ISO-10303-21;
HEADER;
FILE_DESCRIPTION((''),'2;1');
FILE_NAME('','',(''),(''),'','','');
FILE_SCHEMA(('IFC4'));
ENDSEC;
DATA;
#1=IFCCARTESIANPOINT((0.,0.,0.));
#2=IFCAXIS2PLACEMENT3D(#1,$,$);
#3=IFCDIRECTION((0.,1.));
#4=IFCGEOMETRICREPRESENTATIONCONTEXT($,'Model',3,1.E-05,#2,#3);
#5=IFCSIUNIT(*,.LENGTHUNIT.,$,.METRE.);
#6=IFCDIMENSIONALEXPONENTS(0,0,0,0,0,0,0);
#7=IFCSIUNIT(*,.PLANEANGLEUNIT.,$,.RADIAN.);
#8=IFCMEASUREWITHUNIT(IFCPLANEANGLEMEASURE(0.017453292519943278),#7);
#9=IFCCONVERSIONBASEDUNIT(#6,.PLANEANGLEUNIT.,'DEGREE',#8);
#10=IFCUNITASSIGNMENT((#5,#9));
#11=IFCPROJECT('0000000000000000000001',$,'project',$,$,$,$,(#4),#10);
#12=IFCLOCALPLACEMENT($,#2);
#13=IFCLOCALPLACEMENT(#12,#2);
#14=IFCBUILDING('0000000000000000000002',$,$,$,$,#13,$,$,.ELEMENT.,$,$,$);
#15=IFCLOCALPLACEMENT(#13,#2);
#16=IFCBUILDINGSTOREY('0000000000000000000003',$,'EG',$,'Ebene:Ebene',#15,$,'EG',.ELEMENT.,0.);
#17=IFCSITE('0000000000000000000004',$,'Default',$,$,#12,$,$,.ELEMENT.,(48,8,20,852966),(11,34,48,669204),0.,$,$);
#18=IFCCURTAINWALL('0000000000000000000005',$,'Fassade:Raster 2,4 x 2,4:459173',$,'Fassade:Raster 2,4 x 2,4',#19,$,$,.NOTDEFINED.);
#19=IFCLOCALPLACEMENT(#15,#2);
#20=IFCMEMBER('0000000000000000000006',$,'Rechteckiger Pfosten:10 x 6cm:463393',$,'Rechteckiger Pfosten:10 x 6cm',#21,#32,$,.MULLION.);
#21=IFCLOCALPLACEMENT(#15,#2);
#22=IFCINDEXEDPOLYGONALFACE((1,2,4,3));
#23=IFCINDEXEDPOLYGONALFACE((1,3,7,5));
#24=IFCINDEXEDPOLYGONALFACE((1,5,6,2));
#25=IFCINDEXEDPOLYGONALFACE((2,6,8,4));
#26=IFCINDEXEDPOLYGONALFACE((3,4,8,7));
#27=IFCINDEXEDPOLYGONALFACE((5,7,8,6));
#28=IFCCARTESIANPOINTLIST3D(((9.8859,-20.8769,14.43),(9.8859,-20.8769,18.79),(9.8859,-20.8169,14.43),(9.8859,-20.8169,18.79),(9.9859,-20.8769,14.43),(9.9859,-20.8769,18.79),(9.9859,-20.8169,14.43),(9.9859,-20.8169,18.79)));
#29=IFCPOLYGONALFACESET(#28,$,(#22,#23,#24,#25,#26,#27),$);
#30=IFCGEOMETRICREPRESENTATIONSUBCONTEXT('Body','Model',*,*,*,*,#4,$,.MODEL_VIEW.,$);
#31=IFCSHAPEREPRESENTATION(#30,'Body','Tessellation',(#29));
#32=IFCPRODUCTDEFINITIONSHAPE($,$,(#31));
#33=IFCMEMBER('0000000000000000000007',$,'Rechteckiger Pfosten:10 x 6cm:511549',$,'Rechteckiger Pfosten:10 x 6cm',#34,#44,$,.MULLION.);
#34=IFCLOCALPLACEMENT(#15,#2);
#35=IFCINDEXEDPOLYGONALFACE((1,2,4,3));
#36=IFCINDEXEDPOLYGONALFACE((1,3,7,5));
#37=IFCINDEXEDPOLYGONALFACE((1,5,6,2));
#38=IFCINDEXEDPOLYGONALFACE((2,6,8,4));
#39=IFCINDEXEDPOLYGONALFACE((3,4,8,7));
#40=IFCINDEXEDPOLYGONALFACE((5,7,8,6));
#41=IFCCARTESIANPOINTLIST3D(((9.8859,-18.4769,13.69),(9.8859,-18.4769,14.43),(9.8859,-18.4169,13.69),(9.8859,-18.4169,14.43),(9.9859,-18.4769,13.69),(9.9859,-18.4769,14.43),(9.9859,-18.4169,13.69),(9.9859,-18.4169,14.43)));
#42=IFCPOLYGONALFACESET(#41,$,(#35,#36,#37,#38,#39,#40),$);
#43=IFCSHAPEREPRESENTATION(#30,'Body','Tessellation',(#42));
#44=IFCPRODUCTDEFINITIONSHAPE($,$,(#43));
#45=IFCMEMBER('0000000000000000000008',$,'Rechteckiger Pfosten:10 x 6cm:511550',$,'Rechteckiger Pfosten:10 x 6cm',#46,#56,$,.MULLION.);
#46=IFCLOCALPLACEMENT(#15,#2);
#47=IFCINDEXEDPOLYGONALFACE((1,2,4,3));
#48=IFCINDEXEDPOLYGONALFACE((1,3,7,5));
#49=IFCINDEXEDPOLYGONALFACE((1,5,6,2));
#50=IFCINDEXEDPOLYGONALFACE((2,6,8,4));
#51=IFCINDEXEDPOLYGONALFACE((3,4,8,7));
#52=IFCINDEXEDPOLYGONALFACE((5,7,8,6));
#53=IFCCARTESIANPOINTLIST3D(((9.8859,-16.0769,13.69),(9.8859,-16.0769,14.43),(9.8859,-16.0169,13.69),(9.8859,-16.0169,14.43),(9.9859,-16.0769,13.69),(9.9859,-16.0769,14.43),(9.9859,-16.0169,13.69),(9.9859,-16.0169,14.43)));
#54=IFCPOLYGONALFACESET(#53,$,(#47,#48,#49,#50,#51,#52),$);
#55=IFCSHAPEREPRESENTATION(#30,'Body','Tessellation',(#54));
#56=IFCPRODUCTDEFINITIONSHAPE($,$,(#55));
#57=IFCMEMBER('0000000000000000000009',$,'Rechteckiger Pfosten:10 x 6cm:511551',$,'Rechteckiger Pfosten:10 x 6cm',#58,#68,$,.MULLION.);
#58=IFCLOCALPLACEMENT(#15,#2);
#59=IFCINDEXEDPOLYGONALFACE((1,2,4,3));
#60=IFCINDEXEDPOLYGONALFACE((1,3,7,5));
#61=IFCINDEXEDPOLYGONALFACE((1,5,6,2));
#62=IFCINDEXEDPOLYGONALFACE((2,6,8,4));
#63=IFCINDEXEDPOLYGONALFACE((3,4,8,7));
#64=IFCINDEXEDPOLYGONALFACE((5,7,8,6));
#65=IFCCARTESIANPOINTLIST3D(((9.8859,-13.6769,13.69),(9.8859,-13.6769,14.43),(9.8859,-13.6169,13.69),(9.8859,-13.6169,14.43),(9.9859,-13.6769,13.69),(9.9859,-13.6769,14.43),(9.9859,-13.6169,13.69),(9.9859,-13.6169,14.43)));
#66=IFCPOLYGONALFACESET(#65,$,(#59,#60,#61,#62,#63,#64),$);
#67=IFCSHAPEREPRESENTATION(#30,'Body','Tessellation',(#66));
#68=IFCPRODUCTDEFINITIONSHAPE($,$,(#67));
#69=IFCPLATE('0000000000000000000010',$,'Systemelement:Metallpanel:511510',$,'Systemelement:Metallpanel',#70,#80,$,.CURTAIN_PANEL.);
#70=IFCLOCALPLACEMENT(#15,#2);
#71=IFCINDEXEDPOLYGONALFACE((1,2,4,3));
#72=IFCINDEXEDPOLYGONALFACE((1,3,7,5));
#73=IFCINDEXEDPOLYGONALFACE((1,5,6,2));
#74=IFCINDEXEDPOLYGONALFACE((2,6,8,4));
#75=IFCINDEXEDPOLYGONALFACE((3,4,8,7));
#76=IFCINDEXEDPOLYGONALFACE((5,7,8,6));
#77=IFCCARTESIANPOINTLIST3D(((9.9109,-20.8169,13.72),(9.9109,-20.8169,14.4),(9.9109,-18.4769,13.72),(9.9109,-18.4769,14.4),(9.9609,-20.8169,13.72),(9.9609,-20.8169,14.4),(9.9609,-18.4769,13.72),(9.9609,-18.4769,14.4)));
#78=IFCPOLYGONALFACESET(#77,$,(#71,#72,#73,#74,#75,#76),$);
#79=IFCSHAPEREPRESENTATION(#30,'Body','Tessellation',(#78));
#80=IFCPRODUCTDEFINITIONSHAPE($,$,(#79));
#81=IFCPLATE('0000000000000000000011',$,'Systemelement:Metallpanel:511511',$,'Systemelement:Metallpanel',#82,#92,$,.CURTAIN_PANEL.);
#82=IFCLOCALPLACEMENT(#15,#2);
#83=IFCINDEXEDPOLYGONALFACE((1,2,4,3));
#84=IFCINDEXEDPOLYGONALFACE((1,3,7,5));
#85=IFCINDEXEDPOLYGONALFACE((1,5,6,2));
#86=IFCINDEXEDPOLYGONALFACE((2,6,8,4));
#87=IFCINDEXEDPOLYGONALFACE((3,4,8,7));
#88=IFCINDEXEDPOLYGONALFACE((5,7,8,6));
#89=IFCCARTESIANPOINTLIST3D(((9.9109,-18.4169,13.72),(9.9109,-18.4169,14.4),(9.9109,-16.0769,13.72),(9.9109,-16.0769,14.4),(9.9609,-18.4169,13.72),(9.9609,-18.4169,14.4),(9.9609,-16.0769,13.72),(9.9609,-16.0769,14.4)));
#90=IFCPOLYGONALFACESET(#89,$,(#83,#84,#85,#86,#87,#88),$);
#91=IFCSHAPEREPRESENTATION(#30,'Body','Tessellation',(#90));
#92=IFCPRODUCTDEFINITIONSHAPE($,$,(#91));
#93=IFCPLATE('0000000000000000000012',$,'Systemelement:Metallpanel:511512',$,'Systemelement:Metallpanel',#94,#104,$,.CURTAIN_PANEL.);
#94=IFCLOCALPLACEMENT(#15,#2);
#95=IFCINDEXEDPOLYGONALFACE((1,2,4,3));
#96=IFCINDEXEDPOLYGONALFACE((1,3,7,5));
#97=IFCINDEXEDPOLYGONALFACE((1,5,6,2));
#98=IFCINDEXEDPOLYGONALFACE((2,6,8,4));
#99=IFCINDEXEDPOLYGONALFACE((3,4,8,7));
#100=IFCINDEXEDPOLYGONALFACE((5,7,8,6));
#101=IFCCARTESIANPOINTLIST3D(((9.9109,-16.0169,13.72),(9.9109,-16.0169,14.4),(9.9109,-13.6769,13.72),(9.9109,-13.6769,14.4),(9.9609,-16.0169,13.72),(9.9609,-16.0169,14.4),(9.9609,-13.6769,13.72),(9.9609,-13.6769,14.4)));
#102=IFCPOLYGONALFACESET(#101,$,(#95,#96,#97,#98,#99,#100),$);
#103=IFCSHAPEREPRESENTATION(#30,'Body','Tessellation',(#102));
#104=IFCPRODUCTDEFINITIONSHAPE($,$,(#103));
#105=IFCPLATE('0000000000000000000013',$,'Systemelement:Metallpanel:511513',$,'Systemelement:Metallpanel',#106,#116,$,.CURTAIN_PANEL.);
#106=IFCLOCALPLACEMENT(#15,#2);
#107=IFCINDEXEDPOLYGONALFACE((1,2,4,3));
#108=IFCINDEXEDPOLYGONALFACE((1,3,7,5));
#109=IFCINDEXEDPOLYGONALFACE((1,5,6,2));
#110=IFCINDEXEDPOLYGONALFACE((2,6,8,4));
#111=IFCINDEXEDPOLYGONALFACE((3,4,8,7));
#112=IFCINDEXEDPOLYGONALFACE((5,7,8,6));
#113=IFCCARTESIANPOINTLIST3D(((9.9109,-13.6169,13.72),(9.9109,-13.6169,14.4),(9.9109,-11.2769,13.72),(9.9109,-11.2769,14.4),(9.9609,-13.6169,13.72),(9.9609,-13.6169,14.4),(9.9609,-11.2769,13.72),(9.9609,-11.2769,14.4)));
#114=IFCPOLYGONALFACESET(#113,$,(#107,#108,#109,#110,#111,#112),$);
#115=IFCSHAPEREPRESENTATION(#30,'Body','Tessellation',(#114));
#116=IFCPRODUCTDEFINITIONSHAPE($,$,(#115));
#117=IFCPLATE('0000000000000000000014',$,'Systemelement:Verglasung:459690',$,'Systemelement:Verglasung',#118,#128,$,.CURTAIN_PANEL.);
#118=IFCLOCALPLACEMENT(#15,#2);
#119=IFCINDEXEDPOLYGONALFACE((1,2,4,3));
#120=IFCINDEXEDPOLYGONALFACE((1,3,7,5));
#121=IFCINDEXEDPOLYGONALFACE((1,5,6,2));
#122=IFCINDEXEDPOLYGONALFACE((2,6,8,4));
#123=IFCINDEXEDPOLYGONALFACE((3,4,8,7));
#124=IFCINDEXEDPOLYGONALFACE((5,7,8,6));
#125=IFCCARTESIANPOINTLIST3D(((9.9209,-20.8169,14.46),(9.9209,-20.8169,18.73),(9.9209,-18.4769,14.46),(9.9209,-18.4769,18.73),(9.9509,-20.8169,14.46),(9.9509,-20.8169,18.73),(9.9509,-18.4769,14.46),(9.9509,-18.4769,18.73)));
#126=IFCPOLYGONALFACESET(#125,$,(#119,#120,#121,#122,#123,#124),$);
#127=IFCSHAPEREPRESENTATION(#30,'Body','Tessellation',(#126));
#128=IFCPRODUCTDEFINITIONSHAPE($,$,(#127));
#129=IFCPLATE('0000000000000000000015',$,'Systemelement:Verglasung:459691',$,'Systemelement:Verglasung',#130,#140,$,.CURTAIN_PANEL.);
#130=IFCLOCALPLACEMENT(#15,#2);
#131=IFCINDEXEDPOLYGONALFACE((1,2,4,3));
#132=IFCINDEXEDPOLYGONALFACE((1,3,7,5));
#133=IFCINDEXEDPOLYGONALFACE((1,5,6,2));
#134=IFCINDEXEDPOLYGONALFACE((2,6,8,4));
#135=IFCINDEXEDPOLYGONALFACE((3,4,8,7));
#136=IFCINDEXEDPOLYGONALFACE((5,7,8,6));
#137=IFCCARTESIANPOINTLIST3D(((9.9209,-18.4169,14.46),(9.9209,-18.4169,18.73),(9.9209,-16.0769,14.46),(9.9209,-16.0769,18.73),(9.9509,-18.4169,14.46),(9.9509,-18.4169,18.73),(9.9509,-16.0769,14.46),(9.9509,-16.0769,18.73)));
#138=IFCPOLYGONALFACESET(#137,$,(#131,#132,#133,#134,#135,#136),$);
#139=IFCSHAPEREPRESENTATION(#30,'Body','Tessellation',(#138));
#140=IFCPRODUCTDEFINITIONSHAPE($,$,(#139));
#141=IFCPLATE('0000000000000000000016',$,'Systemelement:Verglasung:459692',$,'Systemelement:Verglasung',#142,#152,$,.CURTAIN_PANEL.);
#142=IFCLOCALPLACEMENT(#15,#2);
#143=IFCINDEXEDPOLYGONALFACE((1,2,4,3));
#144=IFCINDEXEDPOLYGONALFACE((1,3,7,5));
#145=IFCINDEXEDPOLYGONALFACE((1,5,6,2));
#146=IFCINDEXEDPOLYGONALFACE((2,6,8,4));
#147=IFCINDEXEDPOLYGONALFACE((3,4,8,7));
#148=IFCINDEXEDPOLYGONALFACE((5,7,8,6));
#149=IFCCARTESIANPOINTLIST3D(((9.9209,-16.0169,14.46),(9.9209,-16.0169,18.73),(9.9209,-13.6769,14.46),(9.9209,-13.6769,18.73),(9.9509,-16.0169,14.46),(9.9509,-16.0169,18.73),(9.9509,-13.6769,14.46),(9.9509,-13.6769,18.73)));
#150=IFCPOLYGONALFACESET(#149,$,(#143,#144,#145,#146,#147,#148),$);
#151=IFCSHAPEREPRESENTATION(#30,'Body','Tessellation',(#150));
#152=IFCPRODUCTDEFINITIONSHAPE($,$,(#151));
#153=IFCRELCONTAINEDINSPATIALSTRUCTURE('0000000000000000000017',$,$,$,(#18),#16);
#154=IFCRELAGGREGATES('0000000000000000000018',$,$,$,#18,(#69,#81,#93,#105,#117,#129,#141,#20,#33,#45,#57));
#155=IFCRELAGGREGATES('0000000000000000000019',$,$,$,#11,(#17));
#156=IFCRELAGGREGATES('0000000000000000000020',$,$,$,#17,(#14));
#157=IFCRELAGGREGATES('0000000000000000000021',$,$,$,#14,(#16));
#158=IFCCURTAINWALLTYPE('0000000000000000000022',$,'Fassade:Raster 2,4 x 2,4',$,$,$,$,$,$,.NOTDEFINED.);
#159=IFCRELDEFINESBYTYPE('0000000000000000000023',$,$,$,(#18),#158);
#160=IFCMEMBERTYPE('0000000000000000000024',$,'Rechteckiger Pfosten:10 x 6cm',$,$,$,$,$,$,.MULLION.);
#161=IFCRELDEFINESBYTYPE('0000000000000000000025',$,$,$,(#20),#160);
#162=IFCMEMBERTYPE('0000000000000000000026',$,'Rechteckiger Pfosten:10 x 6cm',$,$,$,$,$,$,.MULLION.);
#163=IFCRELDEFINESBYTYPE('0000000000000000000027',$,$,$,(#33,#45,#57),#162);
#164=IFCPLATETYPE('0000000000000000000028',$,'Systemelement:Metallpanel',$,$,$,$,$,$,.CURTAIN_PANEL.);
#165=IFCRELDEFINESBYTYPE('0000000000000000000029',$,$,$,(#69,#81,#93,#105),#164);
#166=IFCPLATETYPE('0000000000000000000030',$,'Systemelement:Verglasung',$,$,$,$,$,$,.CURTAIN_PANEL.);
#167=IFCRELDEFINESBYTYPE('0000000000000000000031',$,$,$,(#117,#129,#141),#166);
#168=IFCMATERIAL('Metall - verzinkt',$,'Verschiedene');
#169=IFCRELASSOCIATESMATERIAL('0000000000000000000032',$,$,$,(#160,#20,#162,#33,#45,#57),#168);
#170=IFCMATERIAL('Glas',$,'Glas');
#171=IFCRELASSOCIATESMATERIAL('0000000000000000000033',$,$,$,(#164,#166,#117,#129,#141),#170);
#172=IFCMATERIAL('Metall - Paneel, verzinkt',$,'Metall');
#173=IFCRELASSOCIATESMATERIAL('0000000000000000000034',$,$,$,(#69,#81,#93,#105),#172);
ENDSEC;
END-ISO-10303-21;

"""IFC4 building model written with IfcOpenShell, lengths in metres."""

from ifc_helpers import new_model, entity, si_unit, converted_unit, direction, frame, origin, place, context, subcontext, project, spatial, indexed_curve, outline, extrude, source, transform, mapped, material, type_object, type_shapes, element, aggregate, save


model = new_model("IFC4")

# Units and contexts
model_context = context("Model", 3, precision=1e-05, world=origin(), true_north=direction((0.0, 1.0)))
body_context = subcontext(model_context, "Body", "Model", "MODEL_VIEW")
ifc_project = project(units=[si_unit("LENGTHUNIT", "METRE"), converted_unit("PLANEANGLEUNIT", "DEGREE", entity("IfcPlaneAngleMeasure", 0.017453292519943278), si_unit("PLANEANGLEUNIT", "RADIAN"), dimensions=[0, 0, 0, 0, 0, 0, 0])], contexts=[model_context])

# Site, building, storey
site_placement = place(None, origin())
site = spatial("IfcSite", under=ifc_project, at=site_placement, Name="Default", CompositionType="ELEMENT", RefLatitude=(48, 8, 20, 852966), RefLongitude=(11, 34, 48, 669204), RefElevation=0.0)
building_placement = place(site_placement, origin())
building = spatial("IfcBuilding", under=site, at=building_placement, CompositionType="ELEMENT")
storey_placement = place(building_placement, origin())
storey = spatial("IfcBuildingStorey", under=building, at=storey_placement, Name="EG", ObjectType="Ebene:Ebene", LongName="EG", CompositionType="ELEMENT", Elevation=0.0)

# Curtain wall, members, plates
curtain_wall_type = type_object("IfcCurtainWallType", Name="Fassade:Raster 2,4 x 2,4", PredefinedType="NOTDEFINED")
curtain_wall_placement = place(storey_placement, origin())
curtain_wall = element("IfcCurtainWall", 1, at=curtain_wall_placement, inside=storey, type_object=curtain_wall_type, Name="Fassade:Raster 2,4 x 2,4:459173", ObjectType="Fassade:Raster 2,4 x 2,4", PredefinedType="NOTDEFINED")
ifc_material_1 = material(Name="Metall - verzinkt", Category="Verschiedene")
member_type_1 = type_object("IfcMemberType", Name="Rechteckiger Pfosten:10 x 6cm", PredefinedType="MULLION", material=ifc_material_1)
shared_shape_1 = source(origin(), body_context, "Body", "SweptSolid", [
    extrude(outline(indexed_curve([(-0.03, -0.05), (0.03, -0.05), (0.03, 0.05), (-0.03, 0.05), (-0.03, -0.05)], self_intersect=False)), frame((-0.03, 0.0, -4.36), z_axis=(0.0, 0.0, 1.0), x_axis=(-1.0, 0.0, 0.0)), (0.0, 0.0, 1.0), 4.36),
])
type_shapes(member_type_1, [shared_shape_1])
member_1_placement = place(curtain_wall_placement, frame((9.9359, -20.8769, 18.79), z_axis=(0.0, 0.0, 1.0), x_axis=(0.0, -1.0, 0.0)))
member_1 = element("IfcMember", 2, at=member_1_placement, type_object=member_type_1, material=ifc_material_1, Name="Rechteckiger Pfosten:10 x 6cm:463393", ObjectType="Rechteckiger Pfosten:10 x 6cm", PredefinedType="MULLION", context=body_context, shape_type="MappedRepresentation", body=[
    mapped(shared_shape_1, transform((0.0, 0.0, 0.0), scale=1.0)),
])
member_type_2 = type_object("IfcMemberType", Name="Rechteckiger Pfosten:10 x 6cm", PredefinedType="MULLION", material=ifc_material_1)
shared_shape_2 = source(origin(), body_context, "Body", "SweptSolid", [
    extrude(outline(indexed_curve([(-0.03, -0.05), (0.03, -0.05), (0.03, 0.05), (-0.03, 0.05), (-0.03, -0.05)], self_intersect=False)), frame((0.0, 0.0, -0.74), z_axis=(0.0, 0.0, 1.0), x_axis=(-1.0, 0.0, 0.0)), (0.0, 0.0, 1.0), 0.74),
])
type_shapes(member_type_2, [shared_shape_2])
member_2_placement = place(curtain_wall_placement, frame((9.9359, -18.4469, 13.69), z_axis=(0.0, 0.0, -1.0), x_axis=(0.0, 1.0, 0.0)))
member_2 = element("IfcMember", 3, at=member_2_placement, type_object=member_type_2, material=ifc_material_1, Name="Rechteckiger Pfosten:10 x 6cm:511549", ObjectType="Rechteckiger Pfosten:10 x 6cm", PredefinedType="MULLION", context=body_context, shape_type="MappedRepresentation", body=[
    mapped(shared_shape_2, transform((0.0, 0.0, 0.0), scale=1.0)),
])
member_3_placement = place(curtain_wall_placement, frame((9.9359, -16.0469, 13.69), z_axis=(0.0, 0.0, -1.0), x_axis=(0.0, 1.0, 0.0)))
member_3 = element("IfcMember", 4, at=member_3_placement, type_object=member_type_2, material=ifc_material_1, Name="Rechteckiger Pfosten:10 x 6cm:511550", ObjectType="Rechteckiger Pfosten:10 x 6cm", PredefinedType="MULLION", context=body_context, shape_type="MappedRepresentation", body=[
    mapped(shared_shape_2, transform((0.0, 0.0, 0.0), scale=1.0)),
])
member_4_placement = place(curtain_wall_placement, frame((9.9359, -13.6469, 13.69), z_axis=(0.0, 0.0, -1.0), x_axis=(0.0, 1.0, 0.0)))
member_4 = element("IfcMember", 5, at=member_4_placement, type_object=member_type_2, material=ifc_material_1, Name="Rechteckiger Pfosten:10 x 6cm:511551", ObjectType="Rechteckiger Pfosten:10 x 6cm", PredefinedType="MULLION", context=body_context, shape_type="MappedRepresentation", body=[
    mapped(shared_shape_2, transform((0.0, 0.0, 0.0), scale=1.0)),
])
ifc_material_2 = material(Name="Metall - Paneel, verzinkt", Category="Metall")
ifc_material_3 = material(Name="Glas", Category="Glas")
plate_type_1 = type_object("IfcPlateType", Name="Systemelement:Metallpanel", PredefinedType="CURTAIN_PANEL", material=ifc_material_3)
shared_shape_3 = source(origin(), body_context, "Body", "SweptSolid", [
    extrude(outline(indexed_curve([(-0.025, -1.17), (0.025, -1.17), (0.025, 1.17), (-0.025, 1.17), (-0.025, -1.17)], self_intersect=False)), frame((0.0, 0.0, 0.0), z_axis=(0.0, 0.0, 1.0), x_axis=(0.0, 1.0, 0.0)), (0.0, 0.0, 1.0), 0.68),
])
type_shapes(plate_type_1, [shared_shape_3])
plate_1_placement = place(curtain_wall_placement, frame((9.9359, -19.6469, 13.72), z_axis=(0.0, 0.0, 1.0), x_axis=(0.0, 1.0, 0.0)))
plate_1 = element("IfcPlate", 6, at=plate_1_placement, type_object=plate_type_1, material=ifc_material_2, Name="Systemelement:Metallpanel:511510", ObjectType="Systemelement:Metallpanel", PredefinedType="CURTAIN_PANEL", context=body_context, shape_type="MappedRepresentation", body=[
    mapped(shared_shape_3, transform((0.0, 0.0, 0.0), scale=1.0)),
])
plate_2_placement = place(curtain_wall_placement, frame((9.9359, -17.2469, 13.72), z_axis=(0.0, 0.0, 1.0), x_axis=(0.0, 1.0, 0.0)))
plate_2 = element("IfcPlate", 7, at=plate_2_placement, type_object=plate_type_1, material=ifc_material_2, Name="Systemelement:Metallpanel:511511", ObjectType="Systemelement:Metallpanel", PredefinedType="CURTAIN_PANEL", context=body_context, shape_type="MappedRepresentation", body=[
    mapped(shared_shape_3, transform((0.0, 0.0, 0.0), scale=1.0)),
])
plate_3_placement = place(curtain_wall_placement, frame((9.9359, -14.8469, 13.72), z_axis=(0.0, 0.0, 1.0), x_axis=(0.0, 1.0, 0.0)))
plate_3 = element("IfcPlate", 8, at=plate_3_placement, type_object=plate_type_1, material=ifc_material_2, Name="Systemelement:Metallpanel:511512", ObjectType="Systemelement:Metallpanel", PredefinedType="CURTAIN_PANEL", context=body_context, shape_type="MappedRepresentation", body=[
    mapped(shared_shape_3, transform((0.0, 0.0, 0.0), scale=1.0)),
])
plate_4_placement = place(curtain_wall_placement, frame((9.9359, -12.4469, 13.72), z_axis=(0.0, 0.0, 1.0), x_axis=(0.0, 1.0, 0.0)))
plate_4 = element("IfcPlate", 9, at=plate_4_placement, type_object=plate_type_1, material=ifc_material_2, Name="Systemelement:Metallpanel:511513", ObjectType="Systemelement:Metallpanel", PredefinedType="CURTAIN_PANEL", context=body_context, shape_type="MappedRepresentation", body=[
    mapped(shared_shape_3, transform((0.0, 0.0, 0.0), scale=1.0)),
])
plate_type_2 = type_object("IfcPlateType", Name="Systemelement:Verglasung", PredefinedType="CURTAIN_PANEL", material=ifc_material_3)
shared_shape_4 = source(origin(), body_context, "Body", "SweptSolid", [
    extrude(outline(indexed_curve([(-0.015, -1.17), (0.015, -1.17), (0.015, 1.17), (-0.015, 1.17), (-0.015, -1.17)], self_intersect=False)), frame((0.0, 0.0, 0.0), z_axis=(0.0, 0.0, 1.0), x_axis=(0.0, 1.0, 0.0)), (0.0, 0.0, 1.0), 4.27),
])
type_shapes(plate_type_2, [shared_shape_4])
plate_5_placement = place(curtain_wall_placement, frame((9.9359, -19.6469, 14.46), z_axis=(0.0, 0.0, 1.0), x_axis=(0.0, 1.0, 0.0)))
plate_5 = element("IfcPlate", 10, at=plate_5_placement, type_object=plate_type_2, material=ifc_material_3, Name="Systemelement:Verglasung:459690", ObjectType="Systemelement:Verglasung", PredefinedType="CURTAIN_PANEL", context=body_context, shape_type="MappedRepresentation", body=[
    mapped(shared_shape_4, transform((0.0, 0.0, 0.0), scale=1.0)),
])
plate_6_placement = place(curtain_wall_placement, frame((9.9359, -17.2469, 14.46), z_axis=(0.0, 0.0, 1.0), x_axis=(0.0, 1.0, 0.0)))
plate_6 = element("IfcPlate", 11, at=plate_6_placement, type_object=plate_type_2, material=ifc_material_3, Name="Systemelement:Verglasung:459691", ObjectType="Systemelement:Verglasung", PredefinedType="CURTAIN_PANEL", context=body_context, shape_type="MappedRepresentation", body=[
    mapped(shared_shape_4, transform((0.0, 0.0, 0.0), scale=1.0)),
])
plate_7_placement = place(curtain_wall_placement, frame((9.9359, -14.8469, 14.46), z_axis=(0.0, 0.0, 1.0), x_axis=(0.0, 1.0, 0.0)))
plate_7 = element("IfcPlate", 12, at=plate_7_placement, type_object=plate_type_2, material=ifc_material_3, Name="Systemelement:Verglasung:459692", ObjectType="Systemelement:Verglasung", PredefinedType="CURTAIN_PANEL", context=body_context, shape_type="MappedRepresentation", body=[
    mapped(shared_shape_4, transform((0.0, 0.0, 0.0), scale=1.0)),
])
aggregate(curtain_wall, [plate_1, plate_2, plate_3, plate_4, plate_5, plate_6, plate_7, member_1, member_2, member_3, member_4])

save(model, "model.ifc")
